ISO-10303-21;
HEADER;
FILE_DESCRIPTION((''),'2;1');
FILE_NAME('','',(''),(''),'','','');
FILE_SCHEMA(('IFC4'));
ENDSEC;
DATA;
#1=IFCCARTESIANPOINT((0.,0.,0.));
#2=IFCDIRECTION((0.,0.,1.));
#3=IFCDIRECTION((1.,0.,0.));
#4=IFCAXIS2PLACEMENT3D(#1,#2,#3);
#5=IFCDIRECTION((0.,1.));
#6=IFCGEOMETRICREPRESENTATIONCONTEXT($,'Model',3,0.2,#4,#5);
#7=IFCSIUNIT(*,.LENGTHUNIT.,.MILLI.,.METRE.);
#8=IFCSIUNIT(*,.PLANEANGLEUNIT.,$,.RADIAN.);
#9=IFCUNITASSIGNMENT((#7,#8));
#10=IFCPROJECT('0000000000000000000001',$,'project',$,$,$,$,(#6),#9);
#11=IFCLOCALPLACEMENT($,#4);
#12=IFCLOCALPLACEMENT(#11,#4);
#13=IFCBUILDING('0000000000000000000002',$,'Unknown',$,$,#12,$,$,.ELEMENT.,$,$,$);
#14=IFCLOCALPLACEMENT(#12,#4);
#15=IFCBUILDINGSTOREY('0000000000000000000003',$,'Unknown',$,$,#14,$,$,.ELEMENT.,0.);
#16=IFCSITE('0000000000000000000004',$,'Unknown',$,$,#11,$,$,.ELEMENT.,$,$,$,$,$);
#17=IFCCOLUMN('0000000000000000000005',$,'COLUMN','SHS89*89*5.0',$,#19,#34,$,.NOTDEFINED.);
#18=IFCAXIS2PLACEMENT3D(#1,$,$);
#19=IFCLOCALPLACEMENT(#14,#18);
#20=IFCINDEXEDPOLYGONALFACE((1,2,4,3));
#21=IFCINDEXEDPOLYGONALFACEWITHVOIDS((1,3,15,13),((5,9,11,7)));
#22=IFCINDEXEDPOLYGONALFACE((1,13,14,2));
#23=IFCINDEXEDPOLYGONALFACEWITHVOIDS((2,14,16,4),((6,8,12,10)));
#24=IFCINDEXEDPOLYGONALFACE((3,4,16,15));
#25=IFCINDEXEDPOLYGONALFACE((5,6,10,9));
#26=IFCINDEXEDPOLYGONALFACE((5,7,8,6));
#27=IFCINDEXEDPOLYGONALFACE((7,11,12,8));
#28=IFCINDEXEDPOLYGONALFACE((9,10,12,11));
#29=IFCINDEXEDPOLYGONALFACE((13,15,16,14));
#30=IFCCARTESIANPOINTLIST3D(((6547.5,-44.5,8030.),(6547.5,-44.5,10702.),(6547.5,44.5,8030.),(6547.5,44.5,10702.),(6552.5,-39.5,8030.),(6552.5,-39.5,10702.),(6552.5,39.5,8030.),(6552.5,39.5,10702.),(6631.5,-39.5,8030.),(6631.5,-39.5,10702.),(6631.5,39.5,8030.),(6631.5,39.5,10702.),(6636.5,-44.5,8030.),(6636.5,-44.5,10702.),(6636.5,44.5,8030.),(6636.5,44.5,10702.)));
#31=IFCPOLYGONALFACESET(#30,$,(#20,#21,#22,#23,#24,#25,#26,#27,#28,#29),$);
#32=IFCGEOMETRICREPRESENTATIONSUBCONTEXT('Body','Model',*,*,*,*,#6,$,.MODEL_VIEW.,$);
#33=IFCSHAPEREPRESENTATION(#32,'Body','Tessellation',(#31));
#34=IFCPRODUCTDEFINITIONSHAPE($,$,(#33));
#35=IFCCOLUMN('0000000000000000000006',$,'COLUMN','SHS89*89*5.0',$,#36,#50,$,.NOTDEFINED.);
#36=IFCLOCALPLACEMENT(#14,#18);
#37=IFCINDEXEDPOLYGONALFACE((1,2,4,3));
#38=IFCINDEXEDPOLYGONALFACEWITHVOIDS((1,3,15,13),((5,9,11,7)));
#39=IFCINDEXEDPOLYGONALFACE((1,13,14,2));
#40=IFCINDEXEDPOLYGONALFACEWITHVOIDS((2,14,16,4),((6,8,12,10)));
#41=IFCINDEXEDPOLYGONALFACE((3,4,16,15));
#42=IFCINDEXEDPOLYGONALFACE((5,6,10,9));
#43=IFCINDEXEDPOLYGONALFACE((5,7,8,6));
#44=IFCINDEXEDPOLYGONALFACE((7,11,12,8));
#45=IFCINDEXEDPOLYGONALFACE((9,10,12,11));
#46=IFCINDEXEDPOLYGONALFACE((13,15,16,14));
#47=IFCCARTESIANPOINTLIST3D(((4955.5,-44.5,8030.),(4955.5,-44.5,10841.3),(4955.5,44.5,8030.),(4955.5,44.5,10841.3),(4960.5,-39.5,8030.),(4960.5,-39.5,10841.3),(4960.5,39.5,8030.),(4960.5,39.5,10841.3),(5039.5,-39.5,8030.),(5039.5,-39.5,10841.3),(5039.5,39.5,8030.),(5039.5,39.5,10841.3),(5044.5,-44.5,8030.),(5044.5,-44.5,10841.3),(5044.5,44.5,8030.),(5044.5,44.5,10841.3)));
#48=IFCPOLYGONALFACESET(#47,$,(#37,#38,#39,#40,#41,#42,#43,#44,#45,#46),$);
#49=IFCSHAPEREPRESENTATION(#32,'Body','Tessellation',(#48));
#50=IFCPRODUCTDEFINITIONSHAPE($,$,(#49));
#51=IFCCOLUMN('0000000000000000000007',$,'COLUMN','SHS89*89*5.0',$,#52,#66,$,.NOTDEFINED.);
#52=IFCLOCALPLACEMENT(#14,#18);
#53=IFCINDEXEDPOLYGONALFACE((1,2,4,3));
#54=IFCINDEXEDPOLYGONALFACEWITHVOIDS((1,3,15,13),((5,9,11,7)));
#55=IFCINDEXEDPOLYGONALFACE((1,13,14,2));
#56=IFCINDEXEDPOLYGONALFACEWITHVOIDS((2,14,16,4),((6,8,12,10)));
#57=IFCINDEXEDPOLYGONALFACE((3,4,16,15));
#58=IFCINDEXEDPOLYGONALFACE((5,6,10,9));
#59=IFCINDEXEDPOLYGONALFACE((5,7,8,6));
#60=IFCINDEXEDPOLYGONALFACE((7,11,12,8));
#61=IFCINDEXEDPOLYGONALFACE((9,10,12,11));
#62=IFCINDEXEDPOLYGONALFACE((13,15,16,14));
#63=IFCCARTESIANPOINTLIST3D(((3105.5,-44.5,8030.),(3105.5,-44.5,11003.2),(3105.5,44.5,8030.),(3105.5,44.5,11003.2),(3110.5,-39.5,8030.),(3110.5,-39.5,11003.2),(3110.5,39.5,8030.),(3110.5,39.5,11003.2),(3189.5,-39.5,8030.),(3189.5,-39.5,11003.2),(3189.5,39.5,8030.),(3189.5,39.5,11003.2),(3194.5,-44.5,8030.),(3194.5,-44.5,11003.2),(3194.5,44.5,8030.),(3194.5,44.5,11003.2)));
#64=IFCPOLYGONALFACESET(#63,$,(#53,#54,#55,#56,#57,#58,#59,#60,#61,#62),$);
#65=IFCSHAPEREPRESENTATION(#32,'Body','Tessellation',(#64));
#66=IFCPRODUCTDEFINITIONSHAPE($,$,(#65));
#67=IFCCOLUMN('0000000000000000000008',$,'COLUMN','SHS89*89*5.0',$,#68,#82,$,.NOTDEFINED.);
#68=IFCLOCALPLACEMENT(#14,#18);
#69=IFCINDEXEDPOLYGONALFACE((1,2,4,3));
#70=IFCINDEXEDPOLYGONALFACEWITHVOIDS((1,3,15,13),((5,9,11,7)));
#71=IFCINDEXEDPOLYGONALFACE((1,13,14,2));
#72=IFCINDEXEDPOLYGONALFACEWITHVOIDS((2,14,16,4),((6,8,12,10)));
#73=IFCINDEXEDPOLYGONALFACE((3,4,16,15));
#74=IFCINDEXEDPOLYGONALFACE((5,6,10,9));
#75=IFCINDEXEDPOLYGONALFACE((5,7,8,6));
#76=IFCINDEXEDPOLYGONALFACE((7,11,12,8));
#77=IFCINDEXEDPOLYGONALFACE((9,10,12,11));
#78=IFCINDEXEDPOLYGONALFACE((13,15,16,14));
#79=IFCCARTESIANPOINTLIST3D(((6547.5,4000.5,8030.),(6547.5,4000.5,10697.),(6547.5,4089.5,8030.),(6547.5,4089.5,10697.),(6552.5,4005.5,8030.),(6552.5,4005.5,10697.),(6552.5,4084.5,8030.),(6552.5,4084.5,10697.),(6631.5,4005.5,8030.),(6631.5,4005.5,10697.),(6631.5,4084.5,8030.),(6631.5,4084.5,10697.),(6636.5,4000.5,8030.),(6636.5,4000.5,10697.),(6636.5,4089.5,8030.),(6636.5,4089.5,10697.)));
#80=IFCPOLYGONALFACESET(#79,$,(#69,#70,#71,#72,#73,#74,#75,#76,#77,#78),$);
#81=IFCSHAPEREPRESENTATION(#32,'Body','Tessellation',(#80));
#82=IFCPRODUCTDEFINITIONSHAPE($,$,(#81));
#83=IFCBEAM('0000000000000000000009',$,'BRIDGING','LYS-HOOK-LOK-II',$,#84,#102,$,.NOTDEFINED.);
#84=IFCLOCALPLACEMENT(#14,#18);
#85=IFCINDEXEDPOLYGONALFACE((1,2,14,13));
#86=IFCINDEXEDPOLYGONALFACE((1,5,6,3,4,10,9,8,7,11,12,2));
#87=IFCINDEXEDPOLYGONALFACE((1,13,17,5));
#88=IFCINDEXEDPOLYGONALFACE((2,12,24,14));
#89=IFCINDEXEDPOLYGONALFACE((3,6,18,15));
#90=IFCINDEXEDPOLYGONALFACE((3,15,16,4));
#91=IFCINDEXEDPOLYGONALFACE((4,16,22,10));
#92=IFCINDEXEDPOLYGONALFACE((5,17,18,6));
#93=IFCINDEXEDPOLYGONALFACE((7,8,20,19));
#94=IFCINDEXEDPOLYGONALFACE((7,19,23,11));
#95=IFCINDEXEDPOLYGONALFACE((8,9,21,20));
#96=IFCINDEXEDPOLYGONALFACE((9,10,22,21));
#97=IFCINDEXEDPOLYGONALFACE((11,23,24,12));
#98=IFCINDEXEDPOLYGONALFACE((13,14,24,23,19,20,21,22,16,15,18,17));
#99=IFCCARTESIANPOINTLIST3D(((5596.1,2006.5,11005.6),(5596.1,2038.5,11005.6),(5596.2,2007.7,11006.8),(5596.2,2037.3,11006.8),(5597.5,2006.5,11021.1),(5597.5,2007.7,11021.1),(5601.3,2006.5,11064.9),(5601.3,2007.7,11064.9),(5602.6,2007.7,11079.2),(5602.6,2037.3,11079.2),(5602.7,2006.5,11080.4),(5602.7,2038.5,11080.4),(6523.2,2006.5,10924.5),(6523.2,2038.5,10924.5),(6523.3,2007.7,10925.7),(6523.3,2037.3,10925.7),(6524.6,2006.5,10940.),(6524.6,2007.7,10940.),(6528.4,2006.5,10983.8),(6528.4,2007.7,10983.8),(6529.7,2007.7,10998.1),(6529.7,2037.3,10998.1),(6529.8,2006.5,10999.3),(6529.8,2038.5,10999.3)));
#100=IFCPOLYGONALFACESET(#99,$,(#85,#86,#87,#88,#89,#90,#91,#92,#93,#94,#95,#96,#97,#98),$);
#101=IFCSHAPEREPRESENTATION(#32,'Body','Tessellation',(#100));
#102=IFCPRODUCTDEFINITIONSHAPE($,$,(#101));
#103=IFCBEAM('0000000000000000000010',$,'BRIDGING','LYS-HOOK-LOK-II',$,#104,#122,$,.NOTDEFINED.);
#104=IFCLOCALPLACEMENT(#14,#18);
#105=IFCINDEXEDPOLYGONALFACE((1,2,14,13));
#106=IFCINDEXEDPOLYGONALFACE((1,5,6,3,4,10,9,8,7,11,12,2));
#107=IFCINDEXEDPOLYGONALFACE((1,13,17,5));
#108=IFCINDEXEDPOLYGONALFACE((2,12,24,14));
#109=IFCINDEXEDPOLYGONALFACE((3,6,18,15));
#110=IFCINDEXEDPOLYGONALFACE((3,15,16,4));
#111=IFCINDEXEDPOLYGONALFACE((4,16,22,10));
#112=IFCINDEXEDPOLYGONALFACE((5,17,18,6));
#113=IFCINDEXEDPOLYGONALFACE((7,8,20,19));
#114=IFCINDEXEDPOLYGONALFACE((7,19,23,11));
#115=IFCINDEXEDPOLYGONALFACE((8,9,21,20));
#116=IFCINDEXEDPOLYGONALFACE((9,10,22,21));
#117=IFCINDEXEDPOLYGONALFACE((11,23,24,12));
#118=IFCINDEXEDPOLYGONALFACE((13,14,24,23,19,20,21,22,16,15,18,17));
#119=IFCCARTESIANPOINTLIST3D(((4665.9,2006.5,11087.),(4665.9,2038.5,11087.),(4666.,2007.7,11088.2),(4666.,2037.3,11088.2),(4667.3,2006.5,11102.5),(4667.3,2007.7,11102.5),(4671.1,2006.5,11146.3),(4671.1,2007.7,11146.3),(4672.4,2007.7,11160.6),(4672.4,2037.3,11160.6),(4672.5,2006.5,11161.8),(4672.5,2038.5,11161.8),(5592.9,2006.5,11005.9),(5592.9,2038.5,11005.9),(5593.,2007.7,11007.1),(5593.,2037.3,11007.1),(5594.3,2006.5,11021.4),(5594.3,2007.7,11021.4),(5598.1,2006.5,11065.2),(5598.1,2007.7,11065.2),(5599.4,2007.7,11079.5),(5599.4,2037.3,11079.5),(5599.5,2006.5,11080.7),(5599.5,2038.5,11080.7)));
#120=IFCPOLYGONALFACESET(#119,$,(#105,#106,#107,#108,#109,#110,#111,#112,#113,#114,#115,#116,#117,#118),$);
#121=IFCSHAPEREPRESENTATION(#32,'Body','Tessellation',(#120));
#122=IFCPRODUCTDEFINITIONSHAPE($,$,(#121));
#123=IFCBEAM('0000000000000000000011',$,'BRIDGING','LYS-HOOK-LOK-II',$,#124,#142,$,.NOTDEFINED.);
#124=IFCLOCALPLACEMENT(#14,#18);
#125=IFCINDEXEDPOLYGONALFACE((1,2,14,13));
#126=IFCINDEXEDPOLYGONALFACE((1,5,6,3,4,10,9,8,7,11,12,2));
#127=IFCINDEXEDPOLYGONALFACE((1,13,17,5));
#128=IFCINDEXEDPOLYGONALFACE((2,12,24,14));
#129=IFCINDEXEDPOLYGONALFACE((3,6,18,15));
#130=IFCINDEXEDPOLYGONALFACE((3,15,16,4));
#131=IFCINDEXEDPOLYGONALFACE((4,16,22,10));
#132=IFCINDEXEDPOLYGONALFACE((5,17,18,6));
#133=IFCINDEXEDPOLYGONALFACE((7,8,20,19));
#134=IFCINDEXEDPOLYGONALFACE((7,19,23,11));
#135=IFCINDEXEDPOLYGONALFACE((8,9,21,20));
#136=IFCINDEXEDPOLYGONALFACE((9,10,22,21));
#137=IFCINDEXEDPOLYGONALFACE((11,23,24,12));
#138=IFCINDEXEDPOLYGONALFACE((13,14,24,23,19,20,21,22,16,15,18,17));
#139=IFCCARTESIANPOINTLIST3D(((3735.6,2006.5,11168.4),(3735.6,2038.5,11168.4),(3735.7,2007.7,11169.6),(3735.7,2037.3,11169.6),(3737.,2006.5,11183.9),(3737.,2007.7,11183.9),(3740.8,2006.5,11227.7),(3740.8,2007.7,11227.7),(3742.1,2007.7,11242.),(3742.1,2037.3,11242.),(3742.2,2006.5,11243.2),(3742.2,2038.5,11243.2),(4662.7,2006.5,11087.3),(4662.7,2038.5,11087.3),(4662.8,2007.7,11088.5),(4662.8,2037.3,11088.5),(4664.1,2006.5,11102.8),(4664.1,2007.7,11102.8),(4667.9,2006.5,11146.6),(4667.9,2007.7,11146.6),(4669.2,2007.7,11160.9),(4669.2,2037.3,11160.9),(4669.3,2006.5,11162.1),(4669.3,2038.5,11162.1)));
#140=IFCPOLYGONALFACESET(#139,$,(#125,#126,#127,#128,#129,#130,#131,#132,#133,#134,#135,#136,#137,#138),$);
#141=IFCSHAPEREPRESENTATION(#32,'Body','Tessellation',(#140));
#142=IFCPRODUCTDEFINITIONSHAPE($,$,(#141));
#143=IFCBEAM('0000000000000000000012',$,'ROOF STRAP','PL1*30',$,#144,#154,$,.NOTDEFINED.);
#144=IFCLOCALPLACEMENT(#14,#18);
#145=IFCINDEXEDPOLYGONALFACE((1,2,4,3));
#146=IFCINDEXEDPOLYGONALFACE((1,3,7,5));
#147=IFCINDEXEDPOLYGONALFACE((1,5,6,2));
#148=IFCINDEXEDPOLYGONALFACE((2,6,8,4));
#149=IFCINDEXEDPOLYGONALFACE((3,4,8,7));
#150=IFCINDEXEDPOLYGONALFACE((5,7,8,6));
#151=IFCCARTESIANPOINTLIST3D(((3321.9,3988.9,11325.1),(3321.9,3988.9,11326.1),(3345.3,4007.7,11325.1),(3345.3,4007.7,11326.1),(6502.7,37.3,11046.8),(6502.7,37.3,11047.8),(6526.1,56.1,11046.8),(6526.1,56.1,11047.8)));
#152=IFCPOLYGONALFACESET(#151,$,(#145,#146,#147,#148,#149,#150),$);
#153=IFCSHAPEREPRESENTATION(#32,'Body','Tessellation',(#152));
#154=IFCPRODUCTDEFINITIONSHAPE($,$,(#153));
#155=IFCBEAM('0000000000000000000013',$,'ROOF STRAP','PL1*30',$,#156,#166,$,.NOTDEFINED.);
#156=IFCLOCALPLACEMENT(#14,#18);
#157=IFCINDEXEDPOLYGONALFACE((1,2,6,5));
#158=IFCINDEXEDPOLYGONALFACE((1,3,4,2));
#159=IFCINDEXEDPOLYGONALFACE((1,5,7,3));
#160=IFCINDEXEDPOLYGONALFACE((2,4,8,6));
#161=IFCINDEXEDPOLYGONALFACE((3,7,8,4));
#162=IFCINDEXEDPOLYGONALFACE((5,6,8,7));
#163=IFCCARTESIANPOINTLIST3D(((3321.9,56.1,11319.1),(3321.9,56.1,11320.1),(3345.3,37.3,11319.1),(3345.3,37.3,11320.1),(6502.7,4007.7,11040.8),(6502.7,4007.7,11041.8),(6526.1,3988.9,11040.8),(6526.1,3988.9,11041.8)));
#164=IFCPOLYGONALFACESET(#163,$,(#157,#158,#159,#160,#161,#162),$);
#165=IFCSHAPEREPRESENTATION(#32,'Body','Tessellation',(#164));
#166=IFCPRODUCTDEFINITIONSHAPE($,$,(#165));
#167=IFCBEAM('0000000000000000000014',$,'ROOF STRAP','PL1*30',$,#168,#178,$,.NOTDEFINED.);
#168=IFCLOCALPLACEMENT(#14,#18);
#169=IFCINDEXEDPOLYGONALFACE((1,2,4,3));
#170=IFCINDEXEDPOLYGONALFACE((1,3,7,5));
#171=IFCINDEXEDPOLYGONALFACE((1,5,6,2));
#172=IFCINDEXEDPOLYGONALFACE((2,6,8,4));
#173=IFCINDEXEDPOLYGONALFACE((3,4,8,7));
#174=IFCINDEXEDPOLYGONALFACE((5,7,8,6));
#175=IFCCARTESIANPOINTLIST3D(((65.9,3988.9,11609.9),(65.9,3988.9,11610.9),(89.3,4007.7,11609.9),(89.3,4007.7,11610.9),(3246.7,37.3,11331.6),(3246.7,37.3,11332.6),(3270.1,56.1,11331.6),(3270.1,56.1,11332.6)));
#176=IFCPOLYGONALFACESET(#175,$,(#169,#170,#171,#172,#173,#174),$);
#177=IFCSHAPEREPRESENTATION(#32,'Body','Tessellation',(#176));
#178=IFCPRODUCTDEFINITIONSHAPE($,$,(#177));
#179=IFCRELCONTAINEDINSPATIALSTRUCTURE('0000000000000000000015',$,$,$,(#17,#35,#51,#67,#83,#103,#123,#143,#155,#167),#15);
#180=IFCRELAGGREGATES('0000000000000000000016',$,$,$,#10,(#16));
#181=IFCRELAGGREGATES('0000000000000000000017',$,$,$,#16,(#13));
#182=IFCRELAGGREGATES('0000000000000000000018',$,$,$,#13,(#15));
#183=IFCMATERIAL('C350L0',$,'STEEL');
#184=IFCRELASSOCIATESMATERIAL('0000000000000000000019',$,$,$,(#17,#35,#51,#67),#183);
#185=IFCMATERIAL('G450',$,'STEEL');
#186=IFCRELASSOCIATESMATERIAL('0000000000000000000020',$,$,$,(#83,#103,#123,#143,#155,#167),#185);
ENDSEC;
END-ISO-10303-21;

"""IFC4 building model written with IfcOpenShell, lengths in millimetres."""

from ifc_helpers import new_model, si_unit, direction, frame, origin_with_axes, place, context, subcontext, project, spatial, line, indexed_curve, outline, extrude, material, element, save


model = new_model("IFC4")

# Units and contexts
model_context = context("Model", 3, precision=0.2, world=origin_with_axes(), true_north=direction((0.0, 1.0)))
body_context = subcontext(model_context, "Body", "Model", "MODEL_VIEW")
ifc_project = project(units=[si_unit("LENGTHUNIT", "METRE", prefix="MILLI"), si_unit("PLANEANGLEUNIT", "RADIAN")], contexts=[model_context])

# Site, building, storey
site_placement = place(None, origin_with_axes())
site = spatial("IfcSite", under=ifc_project, at=site_placement, Name="Unknown", CompositionType="ELEMENT")
building_placement = place(site_placement, origin_with_axes())
building = spatial("IfcBuilding", under=site, at=building_placement, Name="Unknown", CompositionType="ELEMENT")
storey_placement = place(building_placement, origin_with_axes())
storey = spatial("IfcBuildingStorey", under=building, at=storey_placement, Name="Unknown", CompositionType="ELEMENT", Elevation=0.0)

# Columns
ifc_material_1 = material(Name="C350L0", Category="STEEL")
column_1_placement = place(storey_placement, frame((6592.0, 0.0, 8030.0), z_axis=(-1.0, 0.0, 0.0), x_axis=(0.0, 0.0, 1.0)))
element("IfcColumn", 1, at=column_1_placement, inside=storey, material=ifc_material_1, Name="COLUMN", Description="SHS89*89*5.0", PredefinedType="NOTDEFINED", context=body_context, shape_type="SolidModel", body=[
    extrude(outline(indexed_curve([(-44.5, -44.5), (44.5, -44.5), (44.5, 44.5), (-44.5, 44.5)], segments=[line(1, 2, 3, 4, 1)]), holes=[indexed_curve([(-39.5, -39.5), (-39.5, 39.5), (39.5, 39.5), (39.5, -39.5)], segments=[line(1, 2, 3, 4, 1)])]), frame((0.0, 0.0, 0.0), z_axis=(-1.0, 0.0, 0.0), x_axis=(0.0, 0.0, 1.0)), (0.0, 0.0, -1.0), 2672.0),
])
column_2_placement = place(storey_placement, frame((5000.0, 0.0, 8030.0), z_axis=(-1.0, 0.0, 0.0), x_axis=(0.0, 0.0, 1.0)))
element("IfcColumn", 2, at=column_2_placement, inside=storey, material=ifc_material_1, Name="COLUMN", Description="SHS89*89*5.0", PredefinedType="NOTDEFINED", context=body_context, shape_type="SolidModel", body=[
    extrude(outline(indexed_curve([(-44.5, -44.5), (44.5, -44.5), (44.5, 44.5), (-44.5, 44.5)], segments=[line(1, 2, 3, 4, 1)]), holes=[indexed_curve([(-39.5, -39.5), (-39.5, 39.5), (39.5, 39.5), (39.5, -39.5)], segments=[line(1, 2, 3, 4, 1)])]), frame((0.0, 0.0, 0.0), z_axis=(-1.0, 0.0, 0.0), x_axis=(0.0, 0.0, 1.0)), (0.0, 0.0, -1.0), 2811.3),
])
column_3_placement = place(storey_placement, frame((3150.0, 0.0, 8030.0), z_axis=(-1.0, 0.0, 0.0), x_axis=(0.0, 0.0, 1.0)))
element("IfcColumn", 3, at=column_3_placement, inside=storey, material=ifc_material_1, Name="COLUMN", Description="SHS89*89*5.0", PredefinedType="NOTDEFINED", context=body_context, shape_type="SolidModel", body=[
    extrude(outline(indexed_curve([(-44.5, -44.5), (44.5, -44.5), (44.5, 44.5), (-44.5, 44.5)], segments=[line(1, 2, 3, 4, 1)]), holes=[indexed_curve([(-39.5, -39.5), (-39.5, 39.5), (39.5, 39.5), (39.5, -39.5)], segments=[line(1, 2, 3, 4, 1)])]), frame((0.0, 0.0, 0.0), z_axis=(-1.0, 0.0, 0.0), x_axis=(0.0, 0.0, 1.0)), (0.0, 0.0, -1.0), 2973.2),
])
column_4_placement = place(storey_placement, frame((6592.0, 4045.0, 8030.0), z_axis=(-1.0, 0.0, 0.0), x_axis=(0.0, 0.0, 1.0)))
element("IfcColumn", 4, at=column_4_placement, inside=storey, material=ifc_material_1, Name="COLUMN", Description="SHS89*89*5.0", PredefinedType="NOTDEFINED", context=body_context, shape_type="SolidModel", body=[
    extrude(outline(indexed_curve([(-44.5, -44.5), (44.5, -44.5), (44.5, 44.5), (-44.5, 44.5)], segments=[line(1, 2, 3, 4, 1)]), holes=[indexed_curve([(-39.5, -39.5), (-39.5, 39.5), (39.5, 39.5), (39.5, -39.5)], segments=[line(1, 2, 3, 4, 1)])]), frame((0.0, 0.0, 0.0), z_axis=(-1.0, 0.0, 0.0), x_axis=(0.0, 0.0, 1.0)), (0.0, 0.0, -1.0), 2667.0),
])

# Beams
ifc_material_2 = material(Name="G450", Category="STEEL")
beam_1_placement = place(storey_placement, frame((5599.4, 2022.5, 11043.0), z_axis=(0.0, -1.0, 0.0), x_axis=(0.996196, 0.0, -0.087144)))
element("IfcBeam", 5, at=beam_1_placement, inside=storey, material=ifc_material_2, Name="BRIDGING", Description="LYS-HOOK-LOK-II", PredefinedType="NOTDEFINED", context=body_context, shape_type="SolidModel", body=[
    extrude(outline(indexed_curve([(16.0, -37.5), (16.0, -22.0), (14.8, -22.0), (14.8, -36.3), (-14.8, -36.3), (-14.8, 36.3), (14.8, 36.3), (14.8, 22.0), (16.0, 22.0), (16.0, 37.5), (-16.0, 37.5), (-16.0, -37.5)], segments=[line(1, 2, 3, 4, 5, 6, 7, 8, 9, 10, 11, 12, 1)])), frame((0.0, 0.0, 0.0), z_axis=(-1.0, 0.0, 0.0), x_axis=(0.0, 0.0, 1.0)), (0.0, 0.0, -1.0), 930.6),
])
beam_2_placement = place(storey_placement, frame((4669.2, 2022.5, 11124.4), z_axis=(0.0, -1.0, 0.0), x_axis=(0.996195, 0.0, -0.087154)))
element("IfcBeam", 6, at=beam_2_placement, inside=storey, material=ifc_material_2, Name="BRIDGING", Description="LYS-HOOK-LOK-II", PredefinedType="NOTDEFINED", context=body_context, shape_type="SolidModel", body=[
    extrude(outline(indexed_curve([(16.0, -37.5), (16.0, -22.0), (14.8, -22.0), (14.8, -36.3), (-14.8, -36.3), (-14.8, 36.3), (14.8, 36.3), (14.8, 22.0), (16.0, 22.0), (16.0, 37.5), (-16.0, 37.5), (-16.0, -37.5)], segments=[line(1, 2, 3, 4, 5, 6, 7, 8, 9, 10, 11, 12, 1)])), frame((0.0, 0.0, 0.0), z_axis=(-1.0, 0.0, 0.0), x_axis=(0.0, 0.0, 1.0)), (0.0, 0.0, -1.0), 930.5),
])
beam_3_placement = place(storey_placement, frame((3738.9, 2022.5, 11205.8), z_axis=(0.0, -1.0, 0.0), x_axis=(0.996196, 0.0, -0.087144)))
element("IfcBeam", 7, at=beam_3_placement, inside=storey, material=ifc_material_2, Name="BRIDGING", Description="LYS-HOOK-LOK-II", PredefinedType="NOTDEFINED", context=body_context, shape_type="SolidModel", body=[
    extrude(outline(indexed_curve([(16.0, -37.5), (16.0, -22.0), (14.8, -22.0), (14.8, -36.3), (-14.8, -36.3), (-14.8, 36.3), (14.8, 36.3), (14.8, 22.0), (16.0, 22.0), (16.0, 37.5), (-16.0, 37.5), (-16.0, -37.5)], segments=[line(1, 2, 3, 4, 5, 6, 7, 8, 9, 10, 11, 12, 1)])), frame((0.0, 0.0, 0.0), z_axis=(-1.0, 0.0, 0.0), x_axis=(0.0, 0.0, 1.0)), (0.0, 0.0, -1.0), 930.6),
])
for number, where, z_axis, x_axis, name in (
    (8, (6514.4, 46.7, 11047.3), (0.034349, -0.042673, 0.998498), (-0.626097, 0.777819, 0.05478), "ROOF STRAP"),
    (9, (3333.6, 46.7, 11319.6), (0.034349, 0.042673, 0.998498), (0.626097, 0.777819, -0.05478), "ROOF STRAP"),
    (10, (3258.4, 46.7, 11332.1), (0.034349, -0.042673, 0.998498), (-0.626097, 0.777819, 0.05478), "ROOF STRAP"),
):
    element("IfcBeam", number, at=place(storey_placement, frame(where, z_axis=z_axis, x_axis=x_axis)), inside=storey, material=ifc_material_2, Name=name, Description="PL1*30", PredefinedType="NOTDEFINED", context=body_context, shape_type="SolidModel", body=[
        extrude(outline(indexed_curve([(-0.5, -15.0), (0.5, -15.0), (0.5, 15.0), (-0.5, 15.0)], segments=[line(1, 2, 3, 4, 1)])), frame((0.0, 0.0, 0.0), z_axis=(-1.0, 0.0, 0.0), x_axis=(0.0, 0.0, 1.0)), (0.0, 0.0, -1.0), 5080.4),
    ])

save(model, "model.ifc")
